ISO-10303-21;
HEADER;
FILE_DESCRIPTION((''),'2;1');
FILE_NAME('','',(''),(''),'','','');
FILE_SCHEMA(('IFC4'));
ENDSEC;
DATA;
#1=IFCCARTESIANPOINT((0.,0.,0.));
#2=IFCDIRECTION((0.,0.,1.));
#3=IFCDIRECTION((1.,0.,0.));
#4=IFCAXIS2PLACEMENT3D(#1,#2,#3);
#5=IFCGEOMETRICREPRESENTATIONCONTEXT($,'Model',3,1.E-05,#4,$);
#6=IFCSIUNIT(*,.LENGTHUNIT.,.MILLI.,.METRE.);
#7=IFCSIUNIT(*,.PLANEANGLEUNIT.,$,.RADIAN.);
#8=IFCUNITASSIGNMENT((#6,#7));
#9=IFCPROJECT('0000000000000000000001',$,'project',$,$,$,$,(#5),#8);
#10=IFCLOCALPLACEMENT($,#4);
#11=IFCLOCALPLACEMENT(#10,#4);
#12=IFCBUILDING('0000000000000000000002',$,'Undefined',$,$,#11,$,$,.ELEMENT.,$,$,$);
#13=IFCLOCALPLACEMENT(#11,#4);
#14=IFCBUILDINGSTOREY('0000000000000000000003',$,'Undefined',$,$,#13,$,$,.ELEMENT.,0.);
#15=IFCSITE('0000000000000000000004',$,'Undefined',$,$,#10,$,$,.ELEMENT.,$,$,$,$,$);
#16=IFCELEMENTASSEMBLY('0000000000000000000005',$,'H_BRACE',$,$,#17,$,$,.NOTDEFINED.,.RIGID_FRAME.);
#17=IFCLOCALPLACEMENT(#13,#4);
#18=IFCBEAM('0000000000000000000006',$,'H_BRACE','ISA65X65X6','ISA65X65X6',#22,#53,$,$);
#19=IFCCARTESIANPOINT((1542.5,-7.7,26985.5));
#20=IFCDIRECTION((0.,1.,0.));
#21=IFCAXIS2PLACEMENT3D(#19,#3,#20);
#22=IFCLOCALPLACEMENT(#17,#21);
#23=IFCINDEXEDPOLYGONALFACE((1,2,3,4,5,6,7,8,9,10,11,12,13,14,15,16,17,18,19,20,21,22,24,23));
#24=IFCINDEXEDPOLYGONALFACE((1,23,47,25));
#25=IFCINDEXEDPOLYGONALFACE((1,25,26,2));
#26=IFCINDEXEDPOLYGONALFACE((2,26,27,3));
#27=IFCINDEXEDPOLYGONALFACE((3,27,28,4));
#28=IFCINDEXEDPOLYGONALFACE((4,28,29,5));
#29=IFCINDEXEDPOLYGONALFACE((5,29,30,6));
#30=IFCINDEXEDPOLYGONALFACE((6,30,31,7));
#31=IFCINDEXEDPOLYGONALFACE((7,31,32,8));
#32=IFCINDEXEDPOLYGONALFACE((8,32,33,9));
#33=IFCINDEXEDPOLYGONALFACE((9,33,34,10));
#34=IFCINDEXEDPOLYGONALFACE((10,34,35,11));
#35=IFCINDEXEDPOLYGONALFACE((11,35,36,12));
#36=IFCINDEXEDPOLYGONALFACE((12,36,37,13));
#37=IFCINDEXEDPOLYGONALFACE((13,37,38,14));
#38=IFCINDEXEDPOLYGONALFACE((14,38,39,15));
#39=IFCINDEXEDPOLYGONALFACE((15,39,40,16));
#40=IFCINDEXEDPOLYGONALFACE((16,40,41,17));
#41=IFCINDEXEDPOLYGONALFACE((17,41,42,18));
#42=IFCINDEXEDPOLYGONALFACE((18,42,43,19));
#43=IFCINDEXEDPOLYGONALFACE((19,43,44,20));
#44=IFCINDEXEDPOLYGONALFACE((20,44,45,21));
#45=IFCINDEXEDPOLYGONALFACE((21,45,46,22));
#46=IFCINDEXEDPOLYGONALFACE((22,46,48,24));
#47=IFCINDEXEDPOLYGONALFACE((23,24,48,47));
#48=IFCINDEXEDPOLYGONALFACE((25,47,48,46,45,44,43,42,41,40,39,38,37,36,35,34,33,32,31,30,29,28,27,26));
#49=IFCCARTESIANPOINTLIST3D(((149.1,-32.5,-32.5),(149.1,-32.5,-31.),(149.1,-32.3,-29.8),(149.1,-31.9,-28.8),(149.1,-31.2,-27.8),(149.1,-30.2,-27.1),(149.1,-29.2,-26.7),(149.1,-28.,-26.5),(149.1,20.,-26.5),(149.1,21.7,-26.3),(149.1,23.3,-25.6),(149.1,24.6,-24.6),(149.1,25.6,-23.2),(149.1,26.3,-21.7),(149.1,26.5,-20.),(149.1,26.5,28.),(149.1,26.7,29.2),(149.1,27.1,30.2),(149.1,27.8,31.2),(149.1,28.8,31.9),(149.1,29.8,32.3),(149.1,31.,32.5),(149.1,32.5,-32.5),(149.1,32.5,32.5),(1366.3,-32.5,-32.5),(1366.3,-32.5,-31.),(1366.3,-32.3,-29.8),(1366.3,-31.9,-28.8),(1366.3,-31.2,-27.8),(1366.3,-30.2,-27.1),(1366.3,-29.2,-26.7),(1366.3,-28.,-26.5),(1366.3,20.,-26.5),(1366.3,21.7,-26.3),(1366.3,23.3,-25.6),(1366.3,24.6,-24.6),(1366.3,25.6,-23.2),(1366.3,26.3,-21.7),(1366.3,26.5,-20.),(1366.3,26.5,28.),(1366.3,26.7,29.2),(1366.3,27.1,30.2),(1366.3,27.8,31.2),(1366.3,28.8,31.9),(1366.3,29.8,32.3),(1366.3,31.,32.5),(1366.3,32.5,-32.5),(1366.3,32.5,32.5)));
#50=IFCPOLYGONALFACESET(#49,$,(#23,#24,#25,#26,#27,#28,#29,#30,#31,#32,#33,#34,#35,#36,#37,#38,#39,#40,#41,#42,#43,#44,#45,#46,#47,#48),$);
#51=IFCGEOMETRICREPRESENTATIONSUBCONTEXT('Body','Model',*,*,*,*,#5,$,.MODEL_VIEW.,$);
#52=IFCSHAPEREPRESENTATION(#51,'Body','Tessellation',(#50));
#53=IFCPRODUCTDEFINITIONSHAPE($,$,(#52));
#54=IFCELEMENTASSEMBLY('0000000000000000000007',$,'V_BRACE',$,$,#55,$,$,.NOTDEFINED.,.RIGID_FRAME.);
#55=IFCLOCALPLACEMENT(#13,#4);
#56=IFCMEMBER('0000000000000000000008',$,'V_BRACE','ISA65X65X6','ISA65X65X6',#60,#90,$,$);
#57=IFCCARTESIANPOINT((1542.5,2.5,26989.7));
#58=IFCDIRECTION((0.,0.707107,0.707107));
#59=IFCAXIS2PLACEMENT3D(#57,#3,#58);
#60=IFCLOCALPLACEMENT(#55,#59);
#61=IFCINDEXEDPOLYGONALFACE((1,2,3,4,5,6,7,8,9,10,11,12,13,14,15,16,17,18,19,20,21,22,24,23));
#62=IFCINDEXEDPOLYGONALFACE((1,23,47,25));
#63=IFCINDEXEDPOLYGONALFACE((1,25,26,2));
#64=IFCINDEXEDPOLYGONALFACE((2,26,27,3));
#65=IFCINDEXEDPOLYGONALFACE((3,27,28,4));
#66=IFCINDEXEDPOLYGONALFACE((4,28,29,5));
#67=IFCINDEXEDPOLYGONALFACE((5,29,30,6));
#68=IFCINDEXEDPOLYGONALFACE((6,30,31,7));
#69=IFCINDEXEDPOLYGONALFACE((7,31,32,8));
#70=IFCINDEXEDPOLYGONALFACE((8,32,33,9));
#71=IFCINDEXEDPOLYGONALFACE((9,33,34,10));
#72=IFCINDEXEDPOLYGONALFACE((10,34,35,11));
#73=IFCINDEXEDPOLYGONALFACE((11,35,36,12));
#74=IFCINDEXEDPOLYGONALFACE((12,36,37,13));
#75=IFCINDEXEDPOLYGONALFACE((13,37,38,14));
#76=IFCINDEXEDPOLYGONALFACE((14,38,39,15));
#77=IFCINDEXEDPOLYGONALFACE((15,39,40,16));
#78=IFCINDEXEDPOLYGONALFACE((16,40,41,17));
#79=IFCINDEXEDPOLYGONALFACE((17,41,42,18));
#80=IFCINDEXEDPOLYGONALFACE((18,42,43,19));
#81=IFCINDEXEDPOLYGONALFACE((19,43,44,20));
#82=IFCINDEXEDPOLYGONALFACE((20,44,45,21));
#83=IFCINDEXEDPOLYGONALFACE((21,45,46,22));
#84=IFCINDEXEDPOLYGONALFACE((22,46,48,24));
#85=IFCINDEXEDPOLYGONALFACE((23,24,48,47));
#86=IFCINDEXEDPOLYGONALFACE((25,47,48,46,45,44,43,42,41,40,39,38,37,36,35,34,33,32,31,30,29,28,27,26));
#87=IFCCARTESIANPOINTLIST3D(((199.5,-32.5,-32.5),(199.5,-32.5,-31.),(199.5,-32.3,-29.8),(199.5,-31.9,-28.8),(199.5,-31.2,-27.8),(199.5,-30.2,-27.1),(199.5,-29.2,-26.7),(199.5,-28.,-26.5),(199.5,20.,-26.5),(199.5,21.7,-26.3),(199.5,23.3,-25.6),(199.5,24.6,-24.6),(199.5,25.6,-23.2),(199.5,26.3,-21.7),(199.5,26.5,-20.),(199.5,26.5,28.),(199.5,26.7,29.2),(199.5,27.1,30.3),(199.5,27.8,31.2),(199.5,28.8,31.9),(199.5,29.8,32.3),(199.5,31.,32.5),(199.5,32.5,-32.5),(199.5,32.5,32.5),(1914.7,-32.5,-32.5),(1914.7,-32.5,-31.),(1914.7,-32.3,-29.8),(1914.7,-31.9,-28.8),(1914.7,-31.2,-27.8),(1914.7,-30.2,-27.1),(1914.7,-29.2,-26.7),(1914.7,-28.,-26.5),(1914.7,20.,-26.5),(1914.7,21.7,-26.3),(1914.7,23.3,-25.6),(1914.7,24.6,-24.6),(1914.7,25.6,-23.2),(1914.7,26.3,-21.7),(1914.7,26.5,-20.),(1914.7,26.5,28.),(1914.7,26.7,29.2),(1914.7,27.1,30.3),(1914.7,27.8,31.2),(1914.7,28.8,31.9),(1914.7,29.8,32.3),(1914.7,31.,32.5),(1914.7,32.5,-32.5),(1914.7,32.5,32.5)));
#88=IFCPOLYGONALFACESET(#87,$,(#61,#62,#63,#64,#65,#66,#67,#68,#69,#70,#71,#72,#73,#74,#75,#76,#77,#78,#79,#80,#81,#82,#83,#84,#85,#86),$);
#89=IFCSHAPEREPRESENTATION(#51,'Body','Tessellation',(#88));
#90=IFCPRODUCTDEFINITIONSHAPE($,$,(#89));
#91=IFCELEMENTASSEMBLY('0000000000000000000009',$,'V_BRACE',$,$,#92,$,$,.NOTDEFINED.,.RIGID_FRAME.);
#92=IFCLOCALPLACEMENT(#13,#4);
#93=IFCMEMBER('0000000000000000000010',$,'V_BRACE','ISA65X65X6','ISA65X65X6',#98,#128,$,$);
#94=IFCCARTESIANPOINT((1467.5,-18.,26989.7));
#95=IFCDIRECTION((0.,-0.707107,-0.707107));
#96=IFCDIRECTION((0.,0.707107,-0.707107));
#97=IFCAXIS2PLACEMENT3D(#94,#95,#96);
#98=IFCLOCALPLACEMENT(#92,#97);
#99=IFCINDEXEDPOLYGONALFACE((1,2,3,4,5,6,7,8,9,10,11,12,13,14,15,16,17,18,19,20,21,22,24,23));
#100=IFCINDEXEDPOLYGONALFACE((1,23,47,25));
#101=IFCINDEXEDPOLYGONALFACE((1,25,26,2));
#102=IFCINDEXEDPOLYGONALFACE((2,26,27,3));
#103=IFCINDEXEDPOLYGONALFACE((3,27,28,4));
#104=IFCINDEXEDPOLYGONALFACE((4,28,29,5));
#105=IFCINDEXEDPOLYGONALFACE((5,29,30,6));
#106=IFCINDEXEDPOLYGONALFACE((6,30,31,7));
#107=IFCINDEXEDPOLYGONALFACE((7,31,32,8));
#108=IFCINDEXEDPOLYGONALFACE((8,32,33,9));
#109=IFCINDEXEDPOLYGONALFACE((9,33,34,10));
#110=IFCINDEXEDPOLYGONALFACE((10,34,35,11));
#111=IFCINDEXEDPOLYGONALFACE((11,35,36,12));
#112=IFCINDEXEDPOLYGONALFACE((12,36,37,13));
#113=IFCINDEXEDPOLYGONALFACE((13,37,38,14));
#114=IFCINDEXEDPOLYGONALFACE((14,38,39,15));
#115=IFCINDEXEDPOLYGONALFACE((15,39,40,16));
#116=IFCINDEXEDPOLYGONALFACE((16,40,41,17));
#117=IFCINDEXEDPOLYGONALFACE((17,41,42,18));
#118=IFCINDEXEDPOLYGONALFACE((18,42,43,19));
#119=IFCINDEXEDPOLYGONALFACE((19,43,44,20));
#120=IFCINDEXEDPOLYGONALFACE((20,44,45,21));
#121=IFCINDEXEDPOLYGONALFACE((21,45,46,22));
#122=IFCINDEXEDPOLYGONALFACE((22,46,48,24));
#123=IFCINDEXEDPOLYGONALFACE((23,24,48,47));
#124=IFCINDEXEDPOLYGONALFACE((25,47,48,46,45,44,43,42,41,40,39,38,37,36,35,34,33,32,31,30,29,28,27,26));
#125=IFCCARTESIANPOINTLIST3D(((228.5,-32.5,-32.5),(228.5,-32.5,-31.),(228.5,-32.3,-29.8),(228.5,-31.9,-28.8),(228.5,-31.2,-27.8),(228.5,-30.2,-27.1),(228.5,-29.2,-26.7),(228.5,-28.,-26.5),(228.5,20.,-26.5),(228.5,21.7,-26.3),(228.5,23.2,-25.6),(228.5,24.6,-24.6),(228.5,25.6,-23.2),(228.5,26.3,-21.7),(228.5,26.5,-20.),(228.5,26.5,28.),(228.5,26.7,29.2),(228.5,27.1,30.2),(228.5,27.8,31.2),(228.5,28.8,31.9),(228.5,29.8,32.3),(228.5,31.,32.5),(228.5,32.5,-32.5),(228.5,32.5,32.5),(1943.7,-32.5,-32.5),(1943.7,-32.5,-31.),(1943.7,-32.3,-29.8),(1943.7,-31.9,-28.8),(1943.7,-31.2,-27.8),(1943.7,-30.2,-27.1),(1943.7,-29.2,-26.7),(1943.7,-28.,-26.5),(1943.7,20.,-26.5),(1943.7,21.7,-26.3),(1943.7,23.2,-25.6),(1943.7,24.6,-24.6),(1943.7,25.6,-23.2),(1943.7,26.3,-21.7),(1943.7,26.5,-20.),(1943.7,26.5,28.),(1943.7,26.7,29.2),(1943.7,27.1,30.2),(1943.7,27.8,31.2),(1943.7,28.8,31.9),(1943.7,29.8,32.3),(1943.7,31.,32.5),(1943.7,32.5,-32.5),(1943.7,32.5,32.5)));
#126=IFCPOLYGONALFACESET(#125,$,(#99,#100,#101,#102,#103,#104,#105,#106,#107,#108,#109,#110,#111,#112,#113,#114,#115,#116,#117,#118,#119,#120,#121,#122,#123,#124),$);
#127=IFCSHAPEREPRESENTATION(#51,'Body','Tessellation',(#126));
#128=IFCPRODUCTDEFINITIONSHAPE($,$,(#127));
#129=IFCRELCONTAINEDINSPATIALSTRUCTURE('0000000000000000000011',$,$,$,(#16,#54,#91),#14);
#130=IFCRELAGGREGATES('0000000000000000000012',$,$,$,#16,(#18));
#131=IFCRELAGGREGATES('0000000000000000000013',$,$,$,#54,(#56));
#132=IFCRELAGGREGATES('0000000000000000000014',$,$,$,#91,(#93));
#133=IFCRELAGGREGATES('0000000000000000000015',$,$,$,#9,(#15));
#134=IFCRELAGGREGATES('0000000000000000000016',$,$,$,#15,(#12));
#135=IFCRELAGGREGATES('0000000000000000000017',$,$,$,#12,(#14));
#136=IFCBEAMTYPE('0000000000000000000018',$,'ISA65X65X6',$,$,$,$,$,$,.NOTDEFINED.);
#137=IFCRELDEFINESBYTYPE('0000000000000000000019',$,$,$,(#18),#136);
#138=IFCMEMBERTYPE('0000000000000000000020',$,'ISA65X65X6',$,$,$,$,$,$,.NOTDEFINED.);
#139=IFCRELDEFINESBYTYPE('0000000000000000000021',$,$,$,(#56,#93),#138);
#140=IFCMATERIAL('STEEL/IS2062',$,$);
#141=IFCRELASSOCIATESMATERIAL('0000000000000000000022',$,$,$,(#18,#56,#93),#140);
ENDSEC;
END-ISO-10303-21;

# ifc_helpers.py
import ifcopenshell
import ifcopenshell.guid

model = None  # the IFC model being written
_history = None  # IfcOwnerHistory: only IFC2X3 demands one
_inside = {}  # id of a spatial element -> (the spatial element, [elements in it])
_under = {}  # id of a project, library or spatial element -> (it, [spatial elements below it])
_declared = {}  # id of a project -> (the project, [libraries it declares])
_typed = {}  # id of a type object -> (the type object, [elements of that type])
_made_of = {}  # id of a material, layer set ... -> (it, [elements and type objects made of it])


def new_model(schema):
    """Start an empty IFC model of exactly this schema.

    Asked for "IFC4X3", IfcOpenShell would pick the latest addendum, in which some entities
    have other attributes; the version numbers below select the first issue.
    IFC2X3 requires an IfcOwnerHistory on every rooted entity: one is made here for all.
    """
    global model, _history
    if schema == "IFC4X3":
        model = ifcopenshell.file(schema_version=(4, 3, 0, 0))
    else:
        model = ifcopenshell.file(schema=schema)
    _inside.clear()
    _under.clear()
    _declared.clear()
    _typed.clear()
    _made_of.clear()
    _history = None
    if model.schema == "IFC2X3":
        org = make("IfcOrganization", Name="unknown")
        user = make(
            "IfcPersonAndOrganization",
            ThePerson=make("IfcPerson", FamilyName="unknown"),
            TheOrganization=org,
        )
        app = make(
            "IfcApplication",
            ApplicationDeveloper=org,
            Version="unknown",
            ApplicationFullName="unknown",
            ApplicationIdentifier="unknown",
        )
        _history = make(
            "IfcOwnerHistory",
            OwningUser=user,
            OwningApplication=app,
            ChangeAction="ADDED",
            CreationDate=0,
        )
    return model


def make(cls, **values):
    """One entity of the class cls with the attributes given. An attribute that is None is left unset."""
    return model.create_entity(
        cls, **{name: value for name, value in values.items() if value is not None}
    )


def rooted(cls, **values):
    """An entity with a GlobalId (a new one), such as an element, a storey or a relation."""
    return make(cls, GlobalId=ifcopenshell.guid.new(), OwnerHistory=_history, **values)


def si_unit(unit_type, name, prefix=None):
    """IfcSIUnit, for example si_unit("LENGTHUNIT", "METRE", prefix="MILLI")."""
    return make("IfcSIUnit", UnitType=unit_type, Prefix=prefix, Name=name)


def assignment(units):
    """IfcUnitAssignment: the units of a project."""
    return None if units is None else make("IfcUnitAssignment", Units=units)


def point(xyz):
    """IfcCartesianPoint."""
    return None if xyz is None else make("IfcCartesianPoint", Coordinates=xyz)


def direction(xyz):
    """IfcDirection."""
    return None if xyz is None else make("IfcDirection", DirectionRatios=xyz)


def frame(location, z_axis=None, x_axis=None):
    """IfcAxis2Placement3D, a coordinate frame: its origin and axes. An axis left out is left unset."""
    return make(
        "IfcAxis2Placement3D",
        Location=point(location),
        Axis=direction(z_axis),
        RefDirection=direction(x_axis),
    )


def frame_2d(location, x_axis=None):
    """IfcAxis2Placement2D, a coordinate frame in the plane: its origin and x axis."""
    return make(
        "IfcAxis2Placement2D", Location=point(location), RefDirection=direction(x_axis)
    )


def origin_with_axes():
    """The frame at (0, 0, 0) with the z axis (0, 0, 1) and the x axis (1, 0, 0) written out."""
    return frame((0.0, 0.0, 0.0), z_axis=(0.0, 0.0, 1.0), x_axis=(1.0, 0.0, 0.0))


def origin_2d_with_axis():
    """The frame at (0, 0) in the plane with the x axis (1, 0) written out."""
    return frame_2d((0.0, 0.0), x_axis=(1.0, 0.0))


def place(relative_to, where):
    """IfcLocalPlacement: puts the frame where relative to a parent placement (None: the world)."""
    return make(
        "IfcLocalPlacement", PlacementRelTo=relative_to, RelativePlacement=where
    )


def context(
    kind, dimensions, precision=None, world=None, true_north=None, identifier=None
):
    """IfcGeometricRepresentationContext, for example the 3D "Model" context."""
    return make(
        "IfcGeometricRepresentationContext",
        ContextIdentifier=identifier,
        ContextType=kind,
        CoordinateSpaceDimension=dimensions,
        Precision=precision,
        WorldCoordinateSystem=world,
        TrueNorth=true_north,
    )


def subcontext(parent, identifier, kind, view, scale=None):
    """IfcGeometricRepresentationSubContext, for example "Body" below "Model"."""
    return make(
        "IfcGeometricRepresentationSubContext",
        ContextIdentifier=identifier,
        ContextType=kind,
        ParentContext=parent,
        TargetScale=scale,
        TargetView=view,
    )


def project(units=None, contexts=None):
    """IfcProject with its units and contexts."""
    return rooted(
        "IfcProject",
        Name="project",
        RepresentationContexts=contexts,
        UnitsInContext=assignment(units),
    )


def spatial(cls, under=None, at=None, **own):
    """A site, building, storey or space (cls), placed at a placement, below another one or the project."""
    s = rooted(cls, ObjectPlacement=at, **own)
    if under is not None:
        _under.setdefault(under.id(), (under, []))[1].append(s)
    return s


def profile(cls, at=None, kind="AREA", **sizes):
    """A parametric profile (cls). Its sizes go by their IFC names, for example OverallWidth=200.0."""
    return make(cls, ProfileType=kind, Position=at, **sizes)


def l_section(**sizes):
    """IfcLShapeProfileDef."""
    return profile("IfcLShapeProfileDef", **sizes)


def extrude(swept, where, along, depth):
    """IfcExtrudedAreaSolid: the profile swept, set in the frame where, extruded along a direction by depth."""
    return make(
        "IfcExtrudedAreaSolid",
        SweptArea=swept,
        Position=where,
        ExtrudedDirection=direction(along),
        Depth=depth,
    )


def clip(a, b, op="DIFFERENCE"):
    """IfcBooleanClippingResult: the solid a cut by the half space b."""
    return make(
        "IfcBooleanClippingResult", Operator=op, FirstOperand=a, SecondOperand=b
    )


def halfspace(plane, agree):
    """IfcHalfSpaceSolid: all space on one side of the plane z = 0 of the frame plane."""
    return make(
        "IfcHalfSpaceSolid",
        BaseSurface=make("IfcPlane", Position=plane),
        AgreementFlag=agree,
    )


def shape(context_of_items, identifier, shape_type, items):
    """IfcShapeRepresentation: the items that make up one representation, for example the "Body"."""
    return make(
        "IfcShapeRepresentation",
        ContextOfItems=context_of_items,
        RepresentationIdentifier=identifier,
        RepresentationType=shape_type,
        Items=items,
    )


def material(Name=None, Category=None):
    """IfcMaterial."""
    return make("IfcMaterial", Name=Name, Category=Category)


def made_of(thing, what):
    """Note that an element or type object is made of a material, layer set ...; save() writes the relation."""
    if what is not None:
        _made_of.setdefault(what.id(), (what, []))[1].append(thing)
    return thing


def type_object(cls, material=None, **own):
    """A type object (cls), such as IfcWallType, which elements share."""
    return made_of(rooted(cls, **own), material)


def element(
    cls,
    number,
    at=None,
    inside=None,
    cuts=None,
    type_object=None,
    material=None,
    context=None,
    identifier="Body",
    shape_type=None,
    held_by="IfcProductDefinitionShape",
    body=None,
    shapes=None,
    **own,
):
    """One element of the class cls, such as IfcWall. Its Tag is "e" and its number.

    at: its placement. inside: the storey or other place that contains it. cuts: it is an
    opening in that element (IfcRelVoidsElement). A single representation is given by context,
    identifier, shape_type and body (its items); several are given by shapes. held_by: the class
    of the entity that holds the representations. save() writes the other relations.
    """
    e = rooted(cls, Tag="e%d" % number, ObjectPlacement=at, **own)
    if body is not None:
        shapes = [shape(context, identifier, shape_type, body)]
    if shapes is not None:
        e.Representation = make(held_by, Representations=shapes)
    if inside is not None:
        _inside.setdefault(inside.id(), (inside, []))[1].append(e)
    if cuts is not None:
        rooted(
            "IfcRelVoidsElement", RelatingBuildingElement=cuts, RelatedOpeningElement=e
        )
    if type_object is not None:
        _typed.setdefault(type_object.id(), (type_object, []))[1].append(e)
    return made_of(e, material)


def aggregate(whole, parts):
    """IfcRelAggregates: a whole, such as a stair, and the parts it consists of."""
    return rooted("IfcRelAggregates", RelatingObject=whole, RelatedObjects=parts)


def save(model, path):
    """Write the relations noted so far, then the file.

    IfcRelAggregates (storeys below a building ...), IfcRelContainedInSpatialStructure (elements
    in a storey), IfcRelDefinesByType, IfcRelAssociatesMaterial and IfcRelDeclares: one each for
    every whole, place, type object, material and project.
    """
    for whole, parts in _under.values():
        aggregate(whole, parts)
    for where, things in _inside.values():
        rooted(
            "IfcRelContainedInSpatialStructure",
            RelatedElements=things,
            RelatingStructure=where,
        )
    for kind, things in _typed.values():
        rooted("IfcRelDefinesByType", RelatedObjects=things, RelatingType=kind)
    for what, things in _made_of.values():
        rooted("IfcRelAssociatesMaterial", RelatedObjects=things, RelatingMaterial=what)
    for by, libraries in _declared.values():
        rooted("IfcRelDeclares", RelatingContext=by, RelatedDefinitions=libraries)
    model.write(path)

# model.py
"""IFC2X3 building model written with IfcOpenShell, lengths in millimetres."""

from ifc_helpers import new_model, si_unit, frame, origin_with_axes, origin_2d_with_axis, place, context, subcontext, project, spatial, l_section, extrude, clip, halfspace, material, type_object, element, aggregate, save


model = new_model("IFC2X3")

# Units and contexts
model_context = context("Model", 3, precision=1e-05, world=origin_with_axes())
body_context = subcontext(model_context, "Body", "Model", "MODEL_VIEW")
ifc_project = project(units=[si_unit("LENGTHUNIT", "METRE", prefix="MILLI"), si_unit("PLANEANGLEUNIT", "RADIAN")], contexts=[model_context])

# Site, building, storey
site_placement = place(None, origin_with_axes())
site = spatial("IfcSite", under=ifc_project, at=site_placement, Name="Undefined", CompositionType="ELEMENT")
building_placement = place(site_placement, origin_with_axes())
building = spatial("IfcBuilding", under=site, at=building_placement, Name="Undefined", CompositionType="ELEMENT")
storey_placement = place(building_placement, origin_with_axes())
storey = spatial("IfcBuildingStorey", under=building, at=storey_placement, Name="Undefined", CompositionType="ELEMENT", Elevation=0.0)

# Shared definitions
ifc_material_1 = material(Name="STEEL/IS2062")

# Element assembly, beam
assembly_1_placement = place(storey_placement, origin_with_axes())
assembly_1 = element("IfcElementAssembly", 1, at=assembly_1_placement, inside=storey, Name="H_BRACE", AssemblyPlace="NOTDEFINED", PredefinedType="RIGID_FRAME")
beam_type_1 = type_object("IfcBeamType", Name="ISA65X65X6", PredefinedType="NOTDEFINED")
beam_1_placement = place(assembly_1_placement, frame((1542.5, -7.7, 26985.5), z_axis=(1.0, 0.0, 0.0), x_axis=(0.0, 1.0, 0.0)))
beam_1 = element("IfcBeam", 2, at=beam_1_placement, type_object=beam_type_1, material=ifc_material_1, Name="H_BRACE", Description="ISA65X65X6", ObjectType="ISA65X65X6", context=body_context, shape_type="Clipping", body=[
    clip(clip(extrude(l_section(Depth=65.0, Width=65.0, Thickness=6.0, FilletRadius=6.5, EdgeRadius=4.5, at=origin_2d_with_axis()), frame((1500.0, 0.0, 0.0), z_axis=(-1.0, 0.0, 0.0), x_axis=(0.0, -1.0, 0.0)), (0.0, 0.0, 1.0), 1500.0), halfspace(frame((1366.3, 0.0, -42.5), z_axis=(-1.0, 0.0, 0.0), x_axis=(0.0, 1.0, 0.0)), True)), halfspace(frame((149.1, 0.0, -32.5), z_axis=(1.0, 0.0, 0.0), x_axis=(0.0, -1.0, 0.0)), True)),
])
aggregate(assembly_1, [beam_1])

# Element assemblies, members
assembly_2_placement = place(storey_placement, origin_with_axes())
assembly_2 = element("IfcElementAssembly", 3, at=assembly_2_placement, inside=storey, Name="V_BRACE", AssemblyPlace="NOTDEFINED", PredefinedType="RIGID_FRAME")
member_type_1 = type_object("IfcMemberType", Name="ISA65X65X6", PredefinedType="NOTDEFINED")
member_1_placement = place(assembly_2_placement, frame((1542.5, 2.5, 26989.7), z_axis=(1.0, 0.0, 0.0), x_axis=(0.0, 0.707107, 0.707107)))
member_1 = element("IfcMember", 4, at=member_1_placement, type_object=member_type_1, material=ifc_material_1, Name="V_BRACE", Description="ISA65X65X6", ObjectType="ISA65X65X6", context=body_context, shape_type="Clipping", body=[
    clip(clip(extrude(l_section(Depth=65.0, Width=65.0, Thickness=6.0, FilletRadius=6.5, EdgeRadius=4.5, at=origin_2d_with_axis()), frame((2121.3, 0.0, 0.0), z_axis=(-1.0, 0.0, 0.0), x_axis=(0.0, -1.0, 0.0)), (0.0, 0.0, 1.0), 2121.3), halfspace(frame((1914.7, 0.0, -42.5), z_axis=(-1.0, 0.0, 0.0), x_axis=(0.0, 1.0, 0.0)), True)), halfspace(frame((199.5, 0.0, -42.5), z_axis=(1.0, 0.0, 0.0), x_axis=(0.0, -1.0, 0.0)), True)),
])
aggregate(assembly_2, [member_1])
assembly_3_placement = place(storey_placement, origin_with_axes())
assembly_3 = element("IfcElementAssembly", 5, at=assembly_3_placement, inside=storey, Name="V_BRACE", AssemblyPlace="NOTDEFINED", PredefinedType="RIGID_FRAME")
member_2_placement = place(assembly_3_placement, frame((1467.5, -18.0, 26989.7), z_axis=(0.0, -0.707107, -0.707107), x_axis=(0.0, 0.707107, -0.707107)))
member_2 = element("IfcMember", 6, at=member_2_placement, type_object=member_type_1, material=ifc_material_1, Name="V_BRACE", Description="ISA65X65X6", ObjectType="ISA65X65X6", context=body_context, shape_type="Clipping", body=[
    clip(clip(extrude(l_section(Depth=65.0, Width=65.0, Thickness=6.0, FilletRadius=6.5, EdgeRadius=4.5, at=origin_2d_with_axis()), frame((2121.3, 0.0, 0.0), z_axis=(-1.0, 0.0, 0.0), x_axis=(0.0, -1.0, 0.0)), (0.0, 0.0, 1.0), 2121.3), halfspace(frame((1943.7, 32.5, 0.0), z_axis=(-1.0, 0.0, 0.0), x_axis=(0.0, 0.0, -1.0)), True)), halfspace(frame((228.5, 32.5, 0.0), z_axis=(1.0, 0.0, 0.0), x_axis=(0.0, 0.0, 1.0)), True)),
])
aggregate(assembly_3, [member_2])

save(model, "model.ifc")
